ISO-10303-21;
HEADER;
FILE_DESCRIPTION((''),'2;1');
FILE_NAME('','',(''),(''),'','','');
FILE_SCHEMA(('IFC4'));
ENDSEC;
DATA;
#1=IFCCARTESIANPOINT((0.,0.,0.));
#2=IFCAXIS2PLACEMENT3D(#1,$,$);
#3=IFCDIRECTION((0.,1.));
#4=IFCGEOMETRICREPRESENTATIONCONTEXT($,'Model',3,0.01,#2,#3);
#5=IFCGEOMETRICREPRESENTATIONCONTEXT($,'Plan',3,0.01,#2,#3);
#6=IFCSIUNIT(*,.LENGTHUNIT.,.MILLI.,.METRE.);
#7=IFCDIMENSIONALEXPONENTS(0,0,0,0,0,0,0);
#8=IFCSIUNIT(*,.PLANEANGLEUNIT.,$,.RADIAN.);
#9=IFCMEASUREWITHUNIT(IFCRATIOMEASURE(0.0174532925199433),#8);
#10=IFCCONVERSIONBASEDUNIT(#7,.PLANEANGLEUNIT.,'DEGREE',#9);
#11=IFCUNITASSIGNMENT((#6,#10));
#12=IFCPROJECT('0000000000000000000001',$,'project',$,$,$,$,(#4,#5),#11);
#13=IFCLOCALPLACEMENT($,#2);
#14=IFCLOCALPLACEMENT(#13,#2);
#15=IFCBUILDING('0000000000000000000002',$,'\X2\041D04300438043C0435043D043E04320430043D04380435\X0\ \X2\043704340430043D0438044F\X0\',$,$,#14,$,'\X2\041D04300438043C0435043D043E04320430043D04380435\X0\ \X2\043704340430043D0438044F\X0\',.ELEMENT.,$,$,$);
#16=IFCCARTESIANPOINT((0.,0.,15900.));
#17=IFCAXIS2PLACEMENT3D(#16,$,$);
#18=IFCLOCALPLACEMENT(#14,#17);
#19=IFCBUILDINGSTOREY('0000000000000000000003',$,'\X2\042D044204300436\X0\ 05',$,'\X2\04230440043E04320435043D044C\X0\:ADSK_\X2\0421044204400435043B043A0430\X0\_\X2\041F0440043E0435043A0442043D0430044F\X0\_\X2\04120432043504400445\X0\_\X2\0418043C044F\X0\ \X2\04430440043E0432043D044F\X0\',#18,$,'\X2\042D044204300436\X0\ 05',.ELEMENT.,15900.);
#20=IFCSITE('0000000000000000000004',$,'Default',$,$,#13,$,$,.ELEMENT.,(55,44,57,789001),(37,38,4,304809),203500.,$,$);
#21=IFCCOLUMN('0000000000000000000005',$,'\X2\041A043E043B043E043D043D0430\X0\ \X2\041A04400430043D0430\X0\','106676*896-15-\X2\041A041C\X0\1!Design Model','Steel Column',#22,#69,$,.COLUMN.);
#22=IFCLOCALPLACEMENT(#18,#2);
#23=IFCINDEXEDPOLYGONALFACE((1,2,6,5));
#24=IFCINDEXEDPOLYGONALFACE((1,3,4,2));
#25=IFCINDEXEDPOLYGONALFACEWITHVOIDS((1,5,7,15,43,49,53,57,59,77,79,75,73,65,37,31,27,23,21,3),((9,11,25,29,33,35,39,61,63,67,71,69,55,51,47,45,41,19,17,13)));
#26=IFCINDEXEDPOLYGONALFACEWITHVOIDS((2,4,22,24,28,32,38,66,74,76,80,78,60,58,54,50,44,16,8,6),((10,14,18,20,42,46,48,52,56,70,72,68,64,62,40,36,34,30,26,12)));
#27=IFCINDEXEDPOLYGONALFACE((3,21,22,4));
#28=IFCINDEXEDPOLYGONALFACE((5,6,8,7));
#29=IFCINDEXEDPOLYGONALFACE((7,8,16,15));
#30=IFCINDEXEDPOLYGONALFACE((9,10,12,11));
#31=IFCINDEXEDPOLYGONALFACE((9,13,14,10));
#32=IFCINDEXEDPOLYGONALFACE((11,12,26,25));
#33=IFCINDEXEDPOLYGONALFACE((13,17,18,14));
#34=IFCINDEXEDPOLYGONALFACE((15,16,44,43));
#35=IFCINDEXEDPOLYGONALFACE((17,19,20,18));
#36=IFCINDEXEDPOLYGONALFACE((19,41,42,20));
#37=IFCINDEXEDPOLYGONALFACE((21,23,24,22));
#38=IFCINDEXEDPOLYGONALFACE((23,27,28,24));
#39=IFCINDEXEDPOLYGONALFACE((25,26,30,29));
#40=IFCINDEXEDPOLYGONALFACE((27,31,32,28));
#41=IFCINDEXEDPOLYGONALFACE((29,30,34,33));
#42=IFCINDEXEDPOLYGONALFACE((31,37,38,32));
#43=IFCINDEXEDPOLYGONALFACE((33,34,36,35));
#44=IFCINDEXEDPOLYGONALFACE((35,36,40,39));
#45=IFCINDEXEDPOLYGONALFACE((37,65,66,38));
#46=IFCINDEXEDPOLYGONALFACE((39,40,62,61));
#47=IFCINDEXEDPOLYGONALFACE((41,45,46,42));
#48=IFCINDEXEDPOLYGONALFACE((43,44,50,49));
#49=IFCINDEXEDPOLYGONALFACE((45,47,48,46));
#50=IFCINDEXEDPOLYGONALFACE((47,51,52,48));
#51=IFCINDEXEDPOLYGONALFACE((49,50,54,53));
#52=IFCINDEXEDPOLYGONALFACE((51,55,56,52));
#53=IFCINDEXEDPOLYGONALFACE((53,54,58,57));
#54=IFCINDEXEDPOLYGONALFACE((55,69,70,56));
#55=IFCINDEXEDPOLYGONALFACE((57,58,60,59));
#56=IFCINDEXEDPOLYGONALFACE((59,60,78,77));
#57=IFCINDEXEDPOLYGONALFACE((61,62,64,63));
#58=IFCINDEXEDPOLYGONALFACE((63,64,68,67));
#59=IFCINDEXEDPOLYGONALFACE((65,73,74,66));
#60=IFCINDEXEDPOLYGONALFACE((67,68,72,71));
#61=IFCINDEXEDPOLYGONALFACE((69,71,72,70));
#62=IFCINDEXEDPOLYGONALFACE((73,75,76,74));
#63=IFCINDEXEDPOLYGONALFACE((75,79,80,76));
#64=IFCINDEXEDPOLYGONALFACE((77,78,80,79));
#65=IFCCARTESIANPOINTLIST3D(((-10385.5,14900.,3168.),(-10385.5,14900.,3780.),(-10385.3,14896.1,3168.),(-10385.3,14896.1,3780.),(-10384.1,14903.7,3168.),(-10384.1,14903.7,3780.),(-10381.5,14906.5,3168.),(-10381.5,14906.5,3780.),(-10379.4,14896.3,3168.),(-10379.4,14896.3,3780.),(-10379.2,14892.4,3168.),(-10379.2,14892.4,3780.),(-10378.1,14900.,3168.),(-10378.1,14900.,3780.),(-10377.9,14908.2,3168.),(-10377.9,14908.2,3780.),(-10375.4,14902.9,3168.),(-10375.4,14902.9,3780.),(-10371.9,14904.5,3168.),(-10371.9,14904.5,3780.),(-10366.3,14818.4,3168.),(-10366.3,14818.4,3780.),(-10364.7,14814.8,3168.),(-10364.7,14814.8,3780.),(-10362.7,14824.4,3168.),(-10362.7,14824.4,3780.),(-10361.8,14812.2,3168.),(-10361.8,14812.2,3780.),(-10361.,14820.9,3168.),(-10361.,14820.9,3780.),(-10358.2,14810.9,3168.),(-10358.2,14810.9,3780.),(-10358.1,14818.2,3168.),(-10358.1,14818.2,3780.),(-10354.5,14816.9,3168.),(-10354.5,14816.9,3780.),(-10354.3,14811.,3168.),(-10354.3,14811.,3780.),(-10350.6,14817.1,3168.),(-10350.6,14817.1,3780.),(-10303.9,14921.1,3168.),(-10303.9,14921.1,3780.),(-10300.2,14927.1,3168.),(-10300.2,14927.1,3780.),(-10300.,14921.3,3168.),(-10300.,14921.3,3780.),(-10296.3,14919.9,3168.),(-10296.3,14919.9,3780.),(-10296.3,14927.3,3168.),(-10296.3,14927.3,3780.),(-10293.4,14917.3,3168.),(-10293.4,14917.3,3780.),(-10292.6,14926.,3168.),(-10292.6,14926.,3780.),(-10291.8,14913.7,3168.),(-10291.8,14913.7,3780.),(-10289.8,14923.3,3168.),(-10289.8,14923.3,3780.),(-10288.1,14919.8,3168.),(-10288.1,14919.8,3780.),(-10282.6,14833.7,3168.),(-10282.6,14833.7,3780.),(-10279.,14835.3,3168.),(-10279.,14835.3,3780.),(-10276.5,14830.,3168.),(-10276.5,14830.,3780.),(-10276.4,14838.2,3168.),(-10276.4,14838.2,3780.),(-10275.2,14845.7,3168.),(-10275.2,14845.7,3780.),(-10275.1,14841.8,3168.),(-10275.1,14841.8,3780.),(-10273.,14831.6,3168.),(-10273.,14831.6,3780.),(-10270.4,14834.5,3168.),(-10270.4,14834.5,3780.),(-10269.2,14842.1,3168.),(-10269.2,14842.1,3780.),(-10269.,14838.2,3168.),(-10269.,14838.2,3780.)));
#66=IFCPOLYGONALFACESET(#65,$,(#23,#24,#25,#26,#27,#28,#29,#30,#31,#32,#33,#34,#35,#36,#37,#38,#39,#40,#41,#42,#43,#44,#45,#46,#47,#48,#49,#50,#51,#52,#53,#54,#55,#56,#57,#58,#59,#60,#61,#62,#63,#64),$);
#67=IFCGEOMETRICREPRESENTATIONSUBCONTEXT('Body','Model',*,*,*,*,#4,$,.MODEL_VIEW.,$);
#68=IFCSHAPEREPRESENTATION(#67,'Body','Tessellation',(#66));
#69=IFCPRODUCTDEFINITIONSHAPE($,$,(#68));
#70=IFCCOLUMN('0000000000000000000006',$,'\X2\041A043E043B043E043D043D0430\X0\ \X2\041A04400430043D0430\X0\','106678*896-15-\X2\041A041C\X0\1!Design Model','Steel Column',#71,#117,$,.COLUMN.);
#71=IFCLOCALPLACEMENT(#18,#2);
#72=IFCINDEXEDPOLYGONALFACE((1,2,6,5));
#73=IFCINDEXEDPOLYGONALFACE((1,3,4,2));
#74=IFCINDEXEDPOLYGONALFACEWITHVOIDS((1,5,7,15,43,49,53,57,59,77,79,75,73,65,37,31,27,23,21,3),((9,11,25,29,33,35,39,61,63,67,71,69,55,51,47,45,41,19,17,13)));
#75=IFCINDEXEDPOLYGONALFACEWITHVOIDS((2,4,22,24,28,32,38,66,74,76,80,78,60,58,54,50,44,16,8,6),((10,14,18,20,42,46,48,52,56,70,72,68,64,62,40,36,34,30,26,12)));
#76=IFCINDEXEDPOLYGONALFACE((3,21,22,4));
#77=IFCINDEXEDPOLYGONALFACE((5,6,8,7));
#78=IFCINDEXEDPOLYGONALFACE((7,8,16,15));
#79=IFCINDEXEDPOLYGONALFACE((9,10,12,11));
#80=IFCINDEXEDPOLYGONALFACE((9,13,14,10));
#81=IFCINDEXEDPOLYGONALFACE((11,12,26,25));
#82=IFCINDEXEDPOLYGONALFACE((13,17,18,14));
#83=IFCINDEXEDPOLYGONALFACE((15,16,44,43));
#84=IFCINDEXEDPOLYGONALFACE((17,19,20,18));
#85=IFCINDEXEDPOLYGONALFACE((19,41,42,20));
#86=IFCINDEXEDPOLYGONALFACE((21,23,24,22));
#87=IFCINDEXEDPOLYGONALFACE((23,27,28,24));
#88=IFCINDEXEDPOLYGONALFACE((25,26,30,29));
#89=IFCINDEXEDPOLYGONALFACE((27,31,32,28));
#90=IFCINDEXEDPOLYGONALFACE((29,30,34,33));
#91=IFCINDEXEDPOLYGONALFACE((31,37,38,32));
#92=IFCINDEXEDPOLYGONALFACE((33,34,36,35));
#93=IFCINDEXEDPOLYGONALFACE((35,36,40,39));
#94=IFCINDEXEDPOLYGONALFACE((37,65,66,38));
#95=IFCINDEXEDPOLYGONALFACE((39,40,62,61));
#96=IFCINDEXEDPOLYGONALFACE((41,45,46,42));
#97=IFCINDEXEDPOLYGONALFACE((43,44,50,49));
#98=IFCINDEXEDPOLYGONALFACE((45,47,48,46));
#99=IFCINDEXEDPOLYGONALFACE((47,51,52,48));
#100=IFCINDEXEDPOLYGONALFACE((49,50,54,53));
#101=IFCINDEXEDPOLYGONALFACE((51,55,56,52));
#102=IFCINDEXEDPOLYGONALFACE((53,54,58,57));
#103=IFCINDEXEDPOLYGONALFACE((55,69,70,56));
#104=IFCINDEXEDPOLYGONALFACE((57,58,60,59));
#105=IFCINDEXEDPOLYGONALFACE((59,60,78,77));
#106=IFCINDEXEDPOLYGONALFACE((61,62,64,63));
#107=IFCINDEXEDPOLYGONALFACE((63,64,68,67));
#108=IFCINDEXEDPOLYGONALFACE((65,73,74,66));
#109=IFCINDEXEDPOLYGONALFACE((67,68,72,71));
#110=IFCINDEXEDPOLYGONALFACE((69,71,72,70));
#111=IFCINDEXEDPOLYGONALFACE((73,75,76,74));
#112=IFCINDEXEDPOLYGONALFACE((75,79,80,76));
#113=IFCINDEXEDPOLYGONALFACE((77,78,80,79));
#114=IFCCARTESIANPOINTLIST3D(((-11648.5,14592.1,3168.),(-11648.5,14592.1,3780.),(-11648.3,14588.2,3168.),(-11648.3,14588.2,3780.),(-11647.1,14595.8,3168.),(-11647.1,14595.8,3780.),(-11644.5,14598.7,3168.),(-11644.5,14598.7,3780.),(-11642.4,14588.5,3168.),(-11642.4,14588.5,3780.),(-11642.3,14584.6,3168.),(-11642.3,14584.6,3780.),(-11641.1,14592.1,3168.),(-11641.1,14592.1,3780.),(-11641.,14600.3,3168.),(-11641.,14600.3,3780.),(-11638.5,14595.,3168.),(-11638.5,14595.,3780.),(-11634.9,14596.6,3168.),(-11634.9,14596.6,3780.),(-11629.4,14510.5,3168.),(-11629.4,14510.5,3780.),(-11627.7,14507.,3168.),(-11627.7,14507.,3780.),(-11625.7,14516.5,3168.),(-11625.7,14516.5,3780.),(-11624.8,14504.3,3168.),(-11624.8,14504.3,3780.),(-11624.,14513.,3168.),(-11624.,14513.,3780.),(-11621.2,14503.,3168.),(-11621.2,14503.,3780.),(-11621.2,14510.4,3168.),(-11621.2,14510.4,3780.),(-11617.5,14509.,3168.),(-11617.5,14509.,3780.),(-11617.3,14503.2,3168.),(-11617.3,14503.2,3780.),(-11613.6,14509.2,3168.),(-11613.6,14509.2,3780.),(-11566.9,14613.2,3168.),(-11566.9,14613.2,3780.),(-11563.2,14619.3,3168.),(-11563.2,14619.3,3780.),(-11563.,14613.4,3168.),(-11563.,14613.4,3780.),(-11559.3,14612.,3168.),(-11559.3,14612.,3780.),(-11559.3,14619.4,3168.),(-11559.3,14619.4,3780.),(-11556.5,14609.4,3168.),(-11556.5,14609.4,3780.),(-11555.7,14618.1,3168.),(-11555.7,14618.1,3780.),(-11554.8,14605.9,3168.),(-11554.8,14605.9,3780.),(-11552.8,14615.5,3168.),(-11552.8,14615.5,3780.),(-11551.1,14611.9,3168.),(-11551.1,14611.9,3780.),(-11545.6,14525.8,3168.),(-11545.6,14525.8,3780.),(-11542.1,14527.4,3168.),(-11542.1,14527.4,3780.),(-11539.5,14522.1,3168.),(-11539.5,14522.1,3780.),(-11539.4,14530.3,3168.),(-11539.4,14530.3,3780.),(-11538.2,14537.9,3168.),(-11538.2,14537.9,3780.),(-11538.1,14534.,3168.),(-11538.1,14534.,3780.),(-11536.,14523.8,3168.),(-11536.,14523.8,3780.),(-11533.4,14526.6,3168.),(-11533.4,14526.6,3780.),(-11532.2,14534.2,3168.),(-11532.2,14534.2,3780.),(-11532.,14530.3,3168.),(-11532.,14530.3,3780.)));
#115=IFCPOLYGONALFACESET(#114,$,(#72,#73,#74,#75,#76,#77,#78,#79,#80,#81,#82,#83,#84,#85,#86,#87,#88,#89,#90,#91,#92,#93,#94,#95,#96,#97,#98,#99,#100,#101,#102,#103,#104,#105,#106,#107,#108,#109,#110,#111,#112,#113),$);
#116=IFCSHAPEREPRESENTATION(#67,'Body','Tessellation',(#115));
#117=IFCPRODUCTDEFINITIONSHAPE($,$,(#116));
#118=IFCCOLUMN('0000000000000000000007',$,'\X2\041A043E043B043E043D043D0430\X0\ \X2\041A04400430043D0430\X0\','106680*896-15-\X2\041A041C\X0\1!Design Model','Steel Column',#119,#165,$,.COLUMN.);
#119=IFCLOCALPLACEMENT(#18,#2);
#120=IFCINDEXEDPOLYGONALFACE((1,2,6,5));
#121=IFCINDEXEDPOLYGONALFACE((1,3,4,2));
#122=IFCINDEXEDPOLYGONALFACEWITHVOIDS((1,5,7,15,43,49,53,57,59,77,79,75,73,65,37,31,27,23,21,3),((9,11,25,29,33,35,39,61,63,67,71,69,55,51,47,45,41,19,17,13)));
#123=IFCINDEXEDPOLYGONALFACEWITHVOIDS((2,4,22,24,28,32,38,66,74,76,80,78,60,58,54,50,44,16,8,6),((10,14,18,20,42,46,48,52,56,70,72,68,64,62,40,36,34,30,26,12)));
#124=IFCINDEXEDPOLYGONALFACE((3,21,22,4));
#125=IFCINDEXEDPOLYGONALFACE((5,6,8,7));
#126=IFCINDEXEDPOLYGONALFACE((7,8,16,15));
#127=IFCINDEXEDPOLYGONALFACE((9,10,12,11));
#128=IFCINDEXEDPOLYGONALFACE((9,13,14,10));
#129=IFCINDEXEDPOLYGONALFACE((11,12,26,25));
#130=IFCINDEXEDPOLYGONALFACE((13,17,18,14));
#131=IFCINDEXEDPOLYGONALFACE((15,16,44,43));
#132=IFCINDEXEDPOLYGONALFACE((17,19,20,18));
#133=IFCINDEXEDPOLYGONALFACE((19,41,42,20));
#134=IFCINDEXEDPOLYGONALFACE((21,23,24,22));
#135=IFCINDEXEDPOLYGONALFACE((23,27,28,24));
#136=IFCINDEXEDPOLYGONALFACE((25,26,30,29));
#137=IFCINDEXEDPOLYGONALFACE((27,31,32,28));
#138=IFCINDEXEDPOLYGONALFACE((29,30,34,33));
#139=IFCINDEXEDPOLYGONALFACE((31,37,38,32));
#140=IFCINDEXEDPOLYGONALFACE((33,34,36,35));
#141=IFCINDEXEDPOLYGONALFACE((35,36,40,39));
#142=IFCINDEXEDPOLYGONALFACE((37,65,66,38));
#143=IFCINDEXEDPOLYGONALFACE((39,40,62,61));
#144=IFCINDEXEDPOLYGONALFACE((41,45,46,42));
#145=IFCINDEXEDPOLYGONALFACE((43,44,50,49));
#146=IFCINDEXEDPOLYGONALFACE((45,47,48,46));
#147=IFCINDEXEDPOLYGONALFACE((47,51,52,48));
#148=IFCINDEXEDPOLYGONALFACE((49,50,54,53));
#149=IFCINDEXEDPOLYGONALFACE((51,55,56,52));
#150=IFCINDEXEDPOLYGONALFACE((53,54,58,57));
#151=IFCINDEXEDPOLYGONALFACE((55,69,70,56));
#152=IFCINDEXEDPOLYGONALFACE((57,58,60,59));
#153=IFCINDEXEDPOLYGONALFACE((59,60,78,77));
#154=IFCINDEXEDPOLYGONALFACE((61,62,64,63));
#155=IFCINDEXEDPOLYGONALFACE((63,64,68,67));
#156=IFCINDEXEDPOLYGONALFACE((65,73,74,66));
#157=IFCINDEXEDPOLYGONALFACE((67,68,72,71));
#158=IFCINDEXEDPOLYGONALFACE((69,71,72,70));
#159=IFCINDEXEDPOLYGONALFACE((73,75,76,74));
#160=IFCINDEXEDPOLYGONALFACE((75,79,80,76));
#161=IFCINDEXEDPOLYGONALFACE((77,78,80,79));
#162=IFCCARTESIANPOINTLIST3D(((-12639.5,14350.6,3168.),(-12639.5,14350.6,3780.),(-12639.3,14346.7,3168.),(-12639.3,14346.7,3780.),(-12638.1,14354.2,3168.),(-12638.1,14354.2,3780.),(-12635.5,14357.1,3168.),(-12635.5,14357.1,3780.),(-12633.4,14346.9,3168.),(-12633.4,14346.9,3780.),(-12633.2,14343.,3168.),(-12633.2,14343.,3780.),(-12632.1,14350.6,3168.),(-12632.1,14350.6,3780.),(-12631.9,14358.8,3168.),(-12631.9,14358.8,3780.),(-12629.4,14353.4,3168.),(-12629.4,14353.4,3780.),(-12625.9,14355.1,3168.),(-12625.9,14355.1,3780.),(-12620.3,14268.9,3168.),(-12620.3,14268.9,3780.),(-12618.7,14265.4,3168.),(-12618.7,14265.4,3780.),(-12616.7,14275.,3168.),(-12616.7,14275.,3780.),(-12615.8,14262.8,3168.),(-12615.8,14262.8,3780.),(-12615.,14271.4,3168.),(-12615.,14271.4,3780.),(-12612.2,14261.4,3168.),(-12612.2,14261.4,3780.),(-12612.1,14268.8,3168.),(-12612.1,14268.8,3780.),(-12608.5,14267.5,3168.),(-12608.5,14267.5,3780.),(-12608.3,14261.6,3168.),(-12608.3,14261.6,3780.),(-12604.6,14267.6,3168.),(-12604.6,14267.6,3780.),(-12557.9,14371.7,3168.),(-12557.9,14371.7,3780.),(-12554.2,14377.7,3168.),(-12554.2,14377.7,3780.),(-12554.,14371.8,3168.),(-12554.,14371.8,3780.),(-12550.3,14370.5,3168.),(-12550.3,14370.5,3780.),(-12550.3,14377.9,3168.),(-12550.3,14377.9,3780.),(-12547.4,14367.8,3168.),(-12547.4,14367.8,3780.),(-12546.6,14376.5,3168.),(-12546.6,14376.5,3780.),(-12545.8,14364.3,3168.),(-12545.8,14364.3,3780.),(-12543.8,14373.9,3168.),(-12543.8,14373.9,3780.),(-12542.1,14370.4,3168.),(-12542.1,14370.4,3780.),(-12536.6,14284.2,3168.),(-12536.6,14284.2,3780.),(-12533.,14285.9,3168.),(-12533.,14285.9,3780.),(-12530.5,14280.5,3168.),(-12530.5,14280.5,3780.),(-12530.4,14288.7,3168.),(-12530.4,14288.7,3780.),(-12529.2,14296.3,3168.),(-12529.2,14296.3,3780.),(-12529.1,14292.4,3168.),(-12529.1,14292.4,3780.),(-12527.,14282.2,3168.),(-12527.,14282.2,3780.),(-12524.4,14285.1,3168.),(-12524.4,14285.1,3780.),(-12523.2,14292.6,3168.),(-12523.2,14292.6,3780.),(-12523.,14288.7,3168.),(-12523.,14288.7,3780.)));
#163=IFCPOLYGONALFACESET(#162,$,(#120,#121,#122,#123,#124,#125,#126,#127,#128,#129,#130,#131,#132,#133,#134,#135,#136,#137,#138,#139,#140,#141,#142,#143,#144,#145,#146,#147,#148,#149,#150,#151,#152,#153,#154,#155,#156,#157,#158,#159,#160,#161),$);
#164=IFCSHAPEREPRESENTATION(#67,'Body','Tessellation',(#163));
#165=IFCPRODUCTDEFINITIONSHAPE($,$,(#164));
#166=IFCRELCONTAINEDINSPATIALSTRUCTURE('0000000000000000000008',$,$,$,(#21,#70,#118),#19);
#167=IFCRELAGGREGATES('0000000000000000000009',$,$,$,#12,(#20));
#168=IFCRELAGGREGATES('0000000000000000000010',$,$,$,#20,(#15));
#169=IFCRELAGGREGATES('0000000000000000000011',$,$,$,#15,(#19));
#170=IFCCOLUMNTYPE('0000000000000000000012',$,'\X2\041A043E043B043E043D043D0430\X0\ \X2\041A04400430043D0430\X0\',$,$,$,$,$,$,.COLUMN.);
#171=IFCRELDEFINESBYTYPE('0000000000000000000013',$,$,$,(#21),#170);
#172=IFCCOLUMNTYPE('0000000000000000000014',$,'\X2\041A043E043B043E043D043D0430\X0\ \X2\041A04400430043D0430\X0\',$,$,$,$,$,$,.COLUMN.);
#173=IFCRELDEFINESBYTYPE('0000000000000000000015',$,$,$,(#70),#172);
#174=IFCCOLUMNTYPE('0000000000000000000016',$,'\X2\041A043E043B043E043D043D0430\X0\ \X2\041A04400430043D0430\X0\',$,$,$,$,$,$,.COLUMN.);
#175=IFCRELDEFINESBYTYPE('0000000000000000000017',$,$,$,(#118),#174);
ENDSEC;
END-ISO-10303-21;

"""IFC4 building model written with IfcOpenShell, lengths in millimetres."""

from ifc_helpers import new_model, entity, si_unit, converted_unit, direction, frame, origin, place, context, subcontext, project, spatial, indexed_curve, outline, extrude, type_object, element, save


model = new_model("IFC4")

# Units and contexts
model_context = context("Model", 3, precision=0.01, world=origin(), true_north=direction((0.0, 1.0)))
plan_context = context("Plan", 3, precision=0.01, world=origin(), true_north=direction((0.0, 1.0)))
body_context = subcontext(model_context, "Body", "Model", "MODEL_VIEW")
ifc_project = project(units=[si_unit("LENGTHUNIT", "METRE", prefix="MILLI"), converted_unit("PLANEANGLEUNIT", "DEGREE", entity("IfcRatioMeasure", 0.0174532925199433), si_unit("PLANEANGLEUNIT", "RADIAN"), dimensions=[0, 0, 0, 0, 0, 0, 0])], contexts=[model_context, plan_context])

# Site, building, storey
site_placement = place(None, origin())
site = spatial("IfcSite", under=ifc_project, at=site_placement, Name="Default", CompositionType="ELEMENT", RefLatitude=(55, 44, 57, 789001), RefLongitude=(37, 38, 4, 304809), RefElevation=203500.0)
building_placement = place(site_placement, origin())
building = spatial("IfcBuilding", under=site, at=building_placement, Name="Наименование здания", LongName="Наименование здания", CompositionType="ELEMENT")
storey_placement = place(building_placement, frame((0.0, 0.0, 15900.0)))
storey = spatial("IfcBuildingStorey", under=building, at=storey_placement, Name="Этаж 05", ObjectType="Уровень:ADSK_Стрелка_Проектная_Вверх_Имя уровня", LongName="Этаж 05", CompositionType="ELEMENT", Elevation=15900.0)

# Columns
column_type_1 = type_object("IfcColumnType", Name="Колонна Крана", PredefinedType="COLUMN")
column_1_placement = place(storey_placement, origin())
element("IfcColumn", 1, at=column_1_placement, inside=storey, type_object=column_type_1, Name="Колонна Крана", Description="106676*896-15-КМ1!Design Model", ObjectType="Steel Column", PredefinedType="COLUMN", context=body_context, shape_type="SweptSolid", body=[
    extrude(outline(indexed_curve([(29.5, -56.8), (33.4, -56.8), (37.0, -55.3), (39.7, -52.6), (41.2, -49.0), (56.8, 29.5), (56.8, 33.4), (55.3, 37.0), (52.6, 39.7), (49.0, 41.2), (-29.5, 56.8), (-33.4, 56.8), (-37.0, 55.3), (-39.7, 52.6), (-41.2, 49.0), (-56.8, -29.5), (-56.8, -33.4), (-55.3, -37.0), (-52.6, -39.7), (-49.0, -41.2), (29.5, -56.8)], self_intersect=False), holes=[indexed_curve([(-43.1, -37.3), (-46.7, -35.8), (-49.5, -33.1), (-51.0, -29.5), (-51.0, -25.5), (-37.3, 43.1), (-35.8, 46.7), (-33.1, 49.5), (-29.5, 51.0), (-25.5, 51.0), (43.1, 37.3), (46.7, 35.8), (49.5, 33.1), (51.0, 29.5), (51.0, 25.5), (37.3, -43.1), (35.8, -46.7), (33.1, -49.5), (29.5, -51.0), (25.5, -51.0), (-43.1, -37.3)], self_intersect=False)]), frame((-10327.2, 14869.1, 3168.0), z_axis=(0.0, 0.0, 1.0), x_axis=(-0.906681, -0.421816, 0.0)), (0.0, 0.0, 1.0), 612.0),
])
column_type_2 = type_object("IfcColumnType", Name="Колонна Крана", PredefinedType="COLUMN")
column_2_placement = place(storey_placement, origin())
element("IfcColumn", 2, at=column_2_placement, inside=storey, type_object=column_type_2, Name="Колонна Крана", Description="106678*896-15-КМ1!Design Model", ObjectType="Steel Column", PredefinedType="COLUMN", context=body_context, shape_type="SweptSolid", body=[
    extrude(outline(indexed_curve([(29.5, -56.8), (33.4, -56.8), (37.0, -55.3), (39.7, -52.6), (41.2, -49.0), (56.8, 29.5), (56.8, 33.4), (55.3, 37.0), (52.6, 39.7), (49.0, 41.2), (-29.5, 56.8), (-33.4, 56.8), (-37.0, 55.3), (-39.7, 52.6), (-41.2, 49.0), (-56.8, -29.5), (-56.8, -33.4), (-55.3, -37.0), (-52.6, -39.7), (-49.0, -41.2), (29.5, -56.8)], self_intersect=False), holes=[indexed_curve([(-43.1, -37.3), (-46.7, -35.8), (-49.5, -33.1), (-51.0, -29.5), (-51.0, -25.5), (-37.3, 43.1), (-35.8, 46.7), (-33.1, 49.5), (-29.5, 51.0), (-25.5, 51.0), (43.1, 37.3), (46.7, 35.8), (49.5, 33.1), (51.0, 29.5), (51.0, 25.5), (37.3, -43.1), (35.8, -46.7), (33.1, -49.5), (29.5, -51.0), (25.5, -51.0), (-43.1, -37.3)], self_intersect=False)]), frame((-11590.3, 14561.2, 3168.0), z_axis=(0.0, 0.0, 1.0), x_axis=(-0.906681, -0.421816, 0.0)), (0.0, 0.0, 1.0), 612.0),
])
column_type_3 = type_object("IfcColumnType", Name="Колонна Крана", PredefinedType="COLUMN")
column_3_placement = place(storey_placement, origin())
element("IfcColumn", 3, at=column_3_placement, inside=storey, type_object=column_type_3, Name="Колонна Крана", Description="106680*896-15-КМ1!Design Model", ObjectType="Steel Column", PredefinedType="COLUMN", context=body_context, shape_type="SweptSolid", body=[
    extrude(outline(indexed_curve([(29.5, -56.8), (33.4, -56.8), (37.0, -55.3), (39.7, -52.6), (41.2, -49.0), (56.8, 29.5), (56.8, 33.4), (55.3, 37.0), (52.6, 39.7), (49.0, 41.2), (-29.5, 56.8), (-33.4, 56.8), (-37.0, 55.3), (-39.7, 52.6), (-41.2, 49.0), (-56.8, -29.5), (-56.8, -33.4), (-55.3, -37.0), (-52.6, -39.7), (-49.0, -41.2), (29.5, -56.8)], self_intersect=False), holes=[indexed_curve([(-43.1, -37.3), (-46.7, -35.8), (-49.5, -33.1), (-51.0, -29.5), (-51.0, -25.5), (-37.3, 43.1), (-35.8, 46.7), (-33.1, 49.5), (-29.5, 51.0), (-25.5, 51.0), (43.1, 37.3), (46.7, 35.8), (49.5, 33.1), (51.0, 29.5), (51.0, 25.5), (37.3, -43.1), (35.8, -46.7), (33.1, -49.5), (29.5, -51.0), (25.5, -51.0), (-43.1, -37.3)], self_intersect=False)]), frame((-12581.2, 14319.6, 3168.0), z_axis=(0.0, 0.0, 1.0), x_axis=(-0.906681, -0.421816, 0.0)), (0.0, 0.0, 1.0), 612.0),
])

save(model, "model.ifc")
